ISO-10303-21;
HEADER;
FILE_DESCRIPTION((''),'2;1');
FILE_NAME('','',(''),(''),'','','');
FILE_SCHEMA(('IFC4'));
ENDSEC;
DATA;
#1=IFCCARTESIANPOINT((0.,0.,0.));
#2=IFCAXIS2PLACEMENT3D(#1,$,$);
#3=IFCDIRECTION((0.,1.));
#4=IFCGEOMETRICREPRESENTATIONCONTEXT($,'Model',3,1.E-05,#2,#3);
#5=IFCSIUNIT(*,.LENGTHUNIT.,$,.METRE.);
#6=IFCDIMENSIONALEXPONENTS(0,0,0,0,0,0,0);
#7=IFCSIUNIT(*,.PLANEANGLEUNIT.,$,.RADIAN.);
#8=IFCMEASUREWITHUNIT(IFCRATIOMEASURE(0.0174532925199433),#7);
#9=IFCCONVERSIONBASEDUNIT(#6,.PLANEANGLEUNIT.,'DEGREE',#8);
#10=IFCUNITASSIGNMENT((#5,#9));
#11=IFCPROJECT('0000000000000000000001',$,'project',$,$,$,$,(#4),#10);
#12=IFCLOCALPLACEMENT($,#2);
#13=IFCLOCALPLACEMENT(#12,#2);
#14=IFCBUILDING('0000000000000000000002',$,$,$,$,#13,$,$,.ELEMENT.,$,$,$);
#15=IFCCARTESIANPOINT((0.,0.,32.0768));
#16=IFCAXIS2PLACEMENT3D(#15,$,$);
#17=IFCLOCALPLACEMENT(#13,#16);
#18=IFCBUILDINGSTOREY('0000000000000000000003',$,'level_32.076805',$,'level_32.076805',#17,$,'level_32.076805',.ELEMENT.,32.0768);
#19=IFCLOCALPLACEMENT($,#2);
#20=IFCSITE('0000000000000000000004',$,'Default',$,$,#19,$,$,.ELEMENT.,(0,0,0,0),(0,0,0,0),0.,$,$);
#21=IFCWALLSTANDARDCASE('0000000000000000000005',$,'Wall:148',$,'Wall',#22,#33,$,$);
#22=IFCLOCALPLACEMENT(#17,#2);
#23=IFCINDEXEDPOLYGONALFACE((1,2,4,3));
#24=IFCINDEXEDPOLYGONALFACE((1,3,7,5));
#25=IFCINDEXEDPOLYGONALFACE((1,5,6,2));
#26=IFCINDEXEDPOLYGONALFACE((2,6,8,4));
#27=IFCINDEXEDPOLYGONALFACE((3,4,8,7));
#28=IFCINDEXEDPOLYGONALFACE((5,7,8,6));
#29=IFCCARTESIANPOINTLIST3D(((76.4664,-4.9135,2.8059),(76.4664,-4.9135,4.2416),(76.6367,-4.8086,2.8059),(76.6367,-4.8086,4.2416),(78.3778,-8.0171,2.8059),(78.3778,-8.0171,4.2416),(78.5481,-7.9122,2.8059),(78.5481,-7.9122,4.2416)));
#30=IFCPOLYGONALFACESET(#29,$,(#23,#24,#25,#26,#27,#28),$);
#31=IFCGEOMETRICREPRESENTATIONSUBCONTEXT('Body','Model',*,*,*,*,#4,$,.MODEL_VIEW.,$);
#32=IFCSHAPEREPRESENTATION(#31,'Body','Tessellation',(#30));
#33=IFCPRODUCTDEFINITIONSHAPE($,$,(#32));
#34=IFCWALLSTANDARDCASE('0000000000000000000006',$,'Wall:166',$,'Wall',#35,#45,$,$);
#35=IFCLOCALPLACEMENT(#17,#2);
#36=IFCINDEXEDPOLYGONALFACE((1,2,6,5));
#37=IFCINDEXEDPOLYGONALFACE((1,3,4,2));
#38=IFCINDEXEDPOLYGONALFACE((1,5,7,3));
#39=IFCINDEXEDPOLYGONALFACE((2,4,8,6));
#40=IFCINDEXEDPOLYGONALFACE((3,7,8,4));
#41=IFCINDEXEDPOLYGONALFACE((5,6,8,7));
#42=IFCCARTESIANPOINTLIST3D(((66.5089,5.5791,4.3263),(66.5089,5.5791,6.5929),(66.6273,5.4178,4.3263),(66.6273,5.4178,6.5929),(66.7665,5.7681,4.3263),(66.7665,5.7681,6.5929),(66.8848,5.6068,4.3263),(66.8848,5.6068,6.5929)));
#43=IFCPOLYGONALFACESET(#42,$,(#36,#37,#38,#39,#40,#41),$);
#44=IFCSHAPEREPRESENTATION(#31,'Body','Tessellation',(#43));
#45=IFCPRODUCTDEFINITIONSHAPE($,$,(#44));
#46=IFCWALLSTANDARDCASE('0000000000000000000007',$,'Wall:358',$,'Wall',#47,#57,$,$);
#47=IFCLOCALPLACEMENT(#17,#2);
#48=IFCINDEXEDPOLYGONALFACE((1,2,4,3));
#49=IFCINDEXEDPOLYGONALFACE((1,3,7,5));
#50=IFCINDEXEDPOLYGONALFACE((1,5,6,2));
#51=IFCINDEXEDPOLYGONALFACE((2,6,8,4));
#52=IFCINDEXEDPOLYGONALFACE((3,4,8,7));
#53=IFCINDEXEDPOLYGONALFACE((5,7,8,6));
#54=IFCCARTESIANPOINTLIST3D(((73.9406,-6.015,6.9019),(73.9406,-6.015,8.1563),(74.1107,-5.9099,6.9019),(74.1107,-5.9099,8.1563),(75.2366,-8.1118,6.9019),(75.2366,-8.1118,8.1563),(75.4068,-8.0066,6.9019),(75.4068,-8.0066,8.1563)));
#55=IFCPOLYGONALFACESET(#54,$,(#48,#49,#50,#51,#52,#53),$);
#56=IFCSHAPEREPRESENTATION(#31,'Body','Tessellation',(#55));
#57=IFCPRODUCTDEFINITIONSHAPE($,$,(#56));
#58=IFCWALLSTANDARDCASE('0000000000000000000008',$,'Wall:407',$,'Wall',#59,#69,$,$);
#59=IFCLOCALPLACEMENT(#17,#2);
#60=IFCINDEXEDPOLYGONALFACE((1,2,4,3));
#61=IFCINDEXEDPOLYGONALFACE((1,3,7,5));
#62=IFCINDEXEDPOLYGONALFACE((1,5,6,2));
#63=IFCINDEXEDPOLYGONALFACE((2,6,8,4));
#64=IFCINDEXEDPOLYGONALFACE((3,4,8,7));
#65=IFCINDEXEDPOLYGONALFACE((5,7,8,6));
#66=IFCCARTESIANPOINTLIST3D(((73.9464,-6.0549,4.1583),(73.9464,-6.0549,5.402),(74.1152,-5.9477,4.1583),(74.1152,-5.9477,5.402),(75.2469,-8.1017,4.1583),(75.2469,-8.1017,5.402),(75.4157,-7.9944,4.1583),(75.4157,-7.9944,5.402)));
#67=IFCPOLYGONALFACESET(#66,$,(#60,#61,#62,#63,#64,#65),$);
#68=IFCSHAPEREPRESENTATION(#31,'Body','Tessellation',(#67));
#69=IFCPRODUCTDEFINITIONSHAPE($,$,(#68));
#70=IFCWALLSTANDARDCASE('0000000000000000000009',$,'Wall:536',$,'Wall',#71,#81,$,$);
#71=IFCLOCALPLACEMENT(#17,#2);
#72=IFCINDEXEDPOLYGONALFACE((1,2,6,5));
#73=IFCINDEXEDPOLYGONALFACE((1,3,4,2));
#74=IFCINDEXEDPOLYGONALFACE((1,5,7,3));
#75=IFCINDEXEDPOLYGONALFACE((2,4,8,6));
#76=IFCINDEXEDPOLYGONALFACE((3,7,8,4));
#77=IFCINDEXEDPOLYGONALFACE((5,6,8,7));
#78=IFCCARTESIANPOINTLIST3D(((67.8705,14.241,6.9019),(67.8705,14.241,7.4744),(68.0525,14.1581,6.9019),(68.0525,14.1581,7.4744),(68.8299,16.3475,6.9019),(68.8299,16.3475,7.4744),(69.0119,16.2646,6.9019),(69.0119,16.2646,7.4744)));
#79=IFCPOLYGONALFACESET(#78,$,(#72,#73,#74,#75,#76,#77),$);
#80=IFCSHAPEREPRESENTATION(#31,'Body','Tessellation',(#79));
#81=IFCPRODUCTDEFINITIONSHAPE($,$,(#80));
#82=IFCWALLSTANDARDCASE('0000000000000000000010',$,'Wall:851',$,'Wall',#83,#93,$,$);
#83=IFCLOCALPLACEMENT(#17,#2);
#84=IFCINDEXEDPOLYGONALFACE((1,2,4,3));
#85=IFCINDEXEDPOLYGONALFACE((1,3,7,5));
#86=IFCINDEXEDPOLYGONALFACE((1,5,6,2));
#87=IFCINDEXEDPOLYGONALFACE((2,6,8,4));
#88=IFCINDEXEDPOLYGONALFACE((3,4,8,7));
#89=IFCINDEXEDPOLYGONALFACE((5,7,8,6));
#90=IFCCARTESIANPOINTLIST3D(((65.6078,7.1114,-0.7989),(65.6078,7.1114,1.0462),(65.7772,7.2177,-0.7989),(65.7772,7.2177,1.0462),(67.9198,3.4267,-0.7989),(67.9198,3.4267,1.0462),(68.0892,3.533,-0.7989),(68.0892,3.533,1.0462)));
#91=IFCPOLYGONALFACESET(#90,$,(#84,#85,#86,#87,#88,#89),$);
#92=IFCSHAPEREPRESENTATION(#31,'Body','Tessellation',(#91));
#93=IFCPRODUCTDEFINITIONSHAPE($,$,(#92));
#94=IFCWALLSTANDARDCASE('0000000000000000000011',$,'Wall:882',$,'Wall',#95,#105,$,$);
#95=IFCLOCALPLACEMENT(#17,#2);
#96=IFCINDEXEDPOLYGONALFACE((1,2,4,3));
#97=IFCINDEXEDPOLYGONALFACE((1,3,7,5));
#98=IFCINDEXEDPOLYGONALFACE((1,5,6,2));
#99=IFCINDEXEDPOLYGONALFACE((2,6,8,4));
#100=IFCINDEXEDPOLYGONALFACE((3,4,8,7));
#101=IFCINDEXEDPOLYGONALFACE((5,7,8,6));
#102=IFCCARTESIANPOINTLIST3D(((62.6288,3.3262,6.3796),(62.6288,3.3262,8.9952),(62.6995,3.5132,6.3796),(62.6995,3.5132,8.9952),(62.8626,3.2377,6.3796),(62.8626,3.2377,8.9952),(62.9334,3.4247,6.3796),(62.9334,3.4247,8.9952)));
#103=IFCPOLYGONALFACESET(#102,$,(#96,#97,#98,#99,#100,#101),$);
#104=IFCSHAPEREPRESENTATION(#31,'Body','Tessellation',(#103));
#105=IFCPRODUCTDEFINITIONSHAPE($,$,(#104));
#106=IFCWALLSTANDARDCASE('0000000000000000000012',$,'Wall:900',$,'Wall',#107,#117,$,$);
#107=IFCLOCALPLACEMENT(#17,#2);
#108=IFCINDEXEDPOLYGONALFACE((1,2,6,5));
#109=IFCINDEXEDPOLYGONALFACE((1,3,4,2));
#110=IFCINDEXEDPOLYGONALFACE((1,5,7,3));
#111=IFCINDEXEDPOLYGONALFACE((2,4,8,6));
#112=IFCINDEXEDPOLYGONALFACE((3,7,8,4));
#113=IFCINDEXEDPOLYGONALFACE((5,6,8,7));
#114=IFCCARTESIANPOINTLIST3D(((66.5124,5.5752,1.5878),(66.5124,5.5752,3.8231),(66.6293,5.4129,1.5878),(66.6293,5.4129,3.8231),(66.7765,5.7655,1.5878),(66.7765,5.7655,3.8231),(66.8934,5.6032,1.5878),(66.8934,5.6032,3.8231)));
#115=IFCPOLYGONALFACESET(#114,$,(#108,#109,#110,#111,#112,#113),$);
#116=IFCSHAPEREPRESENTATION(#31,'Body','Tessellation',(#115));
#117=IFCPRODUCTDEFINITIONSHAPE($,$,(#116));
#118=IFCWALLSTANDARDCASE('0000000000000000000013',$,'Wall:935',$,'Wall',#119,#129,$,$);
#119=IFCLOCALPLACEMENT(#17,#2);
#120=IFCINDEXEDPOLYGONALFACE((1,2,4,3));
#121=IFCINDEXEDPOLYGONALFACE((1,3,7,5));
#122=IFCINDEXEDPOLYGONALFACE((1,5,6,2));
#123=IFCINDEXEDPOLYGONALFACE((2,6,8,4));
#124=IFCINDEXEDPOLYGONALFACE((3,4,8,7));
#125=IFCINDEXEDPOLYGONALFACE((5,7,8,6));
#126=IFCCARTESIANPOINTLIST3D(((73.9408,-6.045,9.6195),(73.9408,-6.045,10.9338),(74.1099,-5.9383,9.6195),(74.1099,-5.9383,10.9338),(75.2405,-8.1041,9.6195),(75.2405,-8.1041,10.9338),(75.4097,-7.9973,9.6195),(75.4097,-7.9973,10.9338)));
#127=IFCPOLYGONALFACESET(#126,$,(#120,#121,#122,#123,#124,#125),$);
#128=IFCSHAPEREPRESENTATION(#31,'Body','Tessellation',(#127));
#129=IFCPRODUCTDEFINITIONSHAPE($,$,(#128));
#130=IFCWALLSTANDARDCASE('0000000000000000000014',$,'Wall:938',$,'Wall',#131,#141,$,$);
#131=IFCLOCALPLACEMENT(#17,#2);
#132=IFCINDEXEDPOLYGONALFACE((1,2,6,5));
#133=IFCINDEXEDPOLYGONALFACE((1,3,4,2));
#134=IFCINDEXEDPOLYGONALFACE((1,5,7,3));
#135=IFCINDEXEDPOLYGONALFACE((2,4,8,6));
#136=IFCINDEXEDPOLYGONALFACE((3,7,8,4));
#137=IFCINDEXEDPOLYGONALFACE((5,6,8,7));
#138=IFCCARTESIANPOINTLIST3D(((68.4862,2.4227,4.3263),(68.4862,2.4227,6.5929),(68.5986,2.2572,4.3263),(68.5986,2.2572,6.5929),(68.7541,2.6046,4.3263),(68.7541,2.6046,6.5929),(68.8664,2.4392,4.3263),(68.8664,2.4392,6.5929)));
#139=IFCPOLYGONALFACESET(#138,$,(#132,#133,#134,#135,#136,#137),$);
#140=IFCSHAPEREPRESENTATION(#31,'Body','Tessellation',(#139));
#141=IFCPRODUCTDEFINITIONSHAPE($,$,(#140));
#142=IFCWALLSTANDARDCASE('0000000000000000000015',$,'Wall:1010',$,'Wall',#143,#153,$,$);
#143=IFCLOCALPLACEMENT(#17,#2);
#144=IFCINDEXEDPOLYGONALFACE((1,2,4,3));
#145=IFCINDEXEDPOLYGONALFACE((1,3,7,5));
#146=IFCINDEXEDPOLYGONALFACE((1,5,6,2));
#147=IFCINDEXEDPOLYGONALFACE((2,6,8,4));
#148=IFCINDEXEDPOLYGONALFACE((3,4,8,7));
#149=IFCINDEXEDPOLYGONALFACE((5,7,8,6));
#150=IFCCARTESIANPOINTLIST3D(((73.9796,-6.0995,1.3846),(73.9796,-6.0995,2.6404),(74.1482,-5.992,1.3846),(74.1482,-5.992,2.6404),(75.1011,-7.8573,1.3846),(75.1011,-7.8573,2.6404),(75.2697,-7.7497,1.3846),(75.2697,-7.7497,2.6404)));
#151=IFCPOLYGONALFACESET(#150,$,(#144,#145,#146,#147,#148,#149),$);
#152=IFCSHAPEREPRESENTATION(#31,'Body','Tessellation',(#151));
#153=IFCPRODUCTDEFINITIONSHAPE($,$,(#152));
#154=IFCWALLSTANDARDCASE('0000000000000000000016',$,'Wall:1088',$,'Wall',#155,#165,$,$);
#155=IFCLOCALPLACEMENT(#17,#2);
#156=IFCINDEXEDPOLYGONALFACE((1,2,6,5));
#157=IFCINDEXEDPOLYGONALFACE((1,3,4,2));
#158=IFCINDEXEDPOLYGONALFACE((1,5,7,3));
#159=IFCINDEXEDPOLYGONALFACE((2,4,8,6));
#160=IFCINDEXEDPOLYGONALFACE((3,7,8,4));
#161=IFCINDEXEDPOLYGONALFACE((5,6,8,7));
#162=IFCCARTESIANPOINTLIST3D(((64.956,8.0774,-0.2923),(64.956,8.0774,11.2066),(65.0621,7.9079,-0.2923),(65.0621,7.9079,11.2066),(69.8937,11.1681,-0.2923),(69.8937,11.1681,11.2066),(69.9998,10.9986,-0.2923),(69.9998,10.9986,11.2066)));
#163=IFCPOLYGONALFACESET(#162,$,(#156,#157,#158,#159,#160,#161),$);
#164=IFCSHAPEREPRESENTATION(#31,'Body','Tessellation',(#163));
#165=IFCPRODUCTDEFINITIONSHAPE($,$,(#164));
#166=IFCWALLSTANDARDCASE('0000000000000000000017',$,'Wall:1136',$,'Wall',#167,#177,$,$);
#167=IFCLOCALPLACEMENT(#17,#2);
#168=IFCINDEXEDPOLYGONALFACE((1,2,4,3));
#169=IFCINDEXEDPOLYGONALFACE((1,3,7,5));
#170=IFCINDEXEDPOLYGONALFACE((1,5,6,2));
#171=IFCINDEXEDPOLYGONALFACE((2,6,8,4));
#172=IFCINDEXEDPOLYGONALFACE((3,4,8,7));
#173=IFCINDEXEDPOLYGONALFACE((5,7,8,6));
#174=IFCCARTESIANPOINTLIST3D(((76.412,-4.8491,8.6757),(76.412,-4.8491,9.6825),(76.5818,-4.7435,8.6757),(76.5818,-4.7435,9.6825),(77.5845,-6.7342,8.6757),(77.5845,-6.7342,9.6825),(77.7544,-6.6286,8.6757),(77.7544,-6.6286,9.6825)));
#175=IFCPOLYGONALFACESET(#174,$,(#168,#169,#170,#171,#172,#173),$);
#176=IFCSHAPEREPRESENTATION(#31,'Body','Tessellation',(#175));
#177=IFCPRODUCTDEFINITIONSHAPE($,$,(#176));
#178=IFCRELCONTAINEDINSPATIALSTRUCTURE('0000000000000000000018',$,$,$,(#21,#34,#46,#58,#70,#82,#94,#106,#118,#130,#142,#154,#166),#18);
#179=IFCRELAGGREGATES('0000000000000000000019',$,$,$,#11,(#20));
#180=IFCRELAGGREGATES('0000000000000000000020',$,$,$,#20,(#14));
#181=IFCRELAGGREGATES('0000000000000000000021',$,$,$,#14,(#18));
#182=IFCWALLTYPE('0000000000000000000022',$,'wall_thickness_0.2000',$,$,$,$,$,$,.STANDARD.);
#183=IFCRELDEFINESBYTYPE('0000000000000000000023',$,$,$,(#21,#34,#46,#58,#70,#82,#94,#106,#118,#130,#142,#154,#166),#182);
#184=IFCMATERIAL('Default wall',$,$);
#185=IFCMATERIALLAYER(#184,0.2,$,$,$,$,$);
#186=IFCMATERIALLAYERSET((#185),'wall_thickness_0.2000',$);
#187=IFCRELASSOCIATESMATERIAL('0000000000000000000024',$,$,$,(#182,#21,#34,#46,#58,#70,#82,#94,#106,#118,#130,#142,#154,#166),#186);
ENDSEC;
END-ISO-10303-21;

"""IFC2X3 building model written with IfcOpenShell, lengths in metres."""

from ifc_helpers import new_model, entity, si_unit, converted_unit, direction, frame, origin, place, context, subcontext, project, spatial, polyline, outline, extrude, material, layer, layer_set, layer_usage, type_object, element, save


model = new_model("IFC2X3")

# Units and contexts
model_context = context("Model", 3, precision=1e-05, world=origin(), true_north=direction((0.0, 1.0)))
body_context = subcontext(model_context, "Body", "Model", "MODEL_VIEW")
ifc_project = project(units=[si_unit("LENGTHUNIT", "METRE"), converted_unit("PLANEANGLEUNIT", "DEGREE", entity("IfcRatioMeasure", 0.0174532925199433), si_unit("PLANEANGLEUNIT", "RADIAN"), dimensions=[0, 0, 0, 0, 0, 0, 0])], contexts=[model_context])

# Site, building, storey
site_placement = place(None, origin())
site = spatial("IfcSite", under=ifc_project, at=site_placement, Name="Default", CompositionType="ELEMENT", RefLatitude=(0, 0, 0, 0), RefLongitude=(0, 0, 0, 0), RefElevation=0.0)
placement_1 = place(None, origin())
building_placement = place(placement_1, origin())
building = spatial("IfcBuilding", under=site, at=building_placement, CompositionType="ELEMENT")
storey_placement = place(building_placement, frame((0.0, 0.0, 32.0768)))
storey = spatial("IfcBuildingStorey", under=building, at=storey_placement, Name="level_32.076805", ObjectType="level_32.076805", LongName="level_32.076805", CompositionType="ELEMENT", Elevation=32.0768)

# Walls
ifc_material_1 = material(Name="Default wall")
ifc_layer = layer(ifc_material_1, 0.2)
ifc_layer_set = layer_set([ifc_layer], Name="wall_thickness_0.2000")
ifc_layer_usage = layer_usage(ifc_layer_set, "AXIS2", "POSITIVE", -0.1)
wall_type = type_object("IfcWallType", Name="wall_thickness_0.2000", PredefinedType="STANDARD", material=ifc_layer_set)
placement_2 = place(building_placement, frame((0.0, 0.0, 34.8827)))
wall_1_placement = place(placement_2, frame((76.5516, -4.861, 0.0), z_axis=(0.0, 0.0, 1.0), x_axis=(0.524394, -0.851476, 0.0)))
element("IfcWallStandardCase", 1, at=wall_1_placement, inside=storey, type_object=wall_type, material=ifc_layer_usage, Name="Wall:148", ObjectType="Wall", context=body_context, shape_type="SweptSolid", body=[
    extrude(outline(polyline([(3.645, -0.1), (3.645, 0.1), (0.0, 0.1), (0.0, -0.1), (3.645, -0.1)])), origin(), (0.0, 0.0, 1.0), 1.4358),
])
placement_3 = place(building_placement, frame((0.0, 0.0, 36.4031)))
wall_2_placement = place(placement_3, frame((66.8256, 5.6874, 0.0), z_axis=(0.0, 0.0, 1.0), x_axis=(-0.806218, -0.591618, 0.0)))
element("IfcWallStandardCase", 2, at=wall_2_placement, inside=storey, type_object=wall_type, material=ifc_layer_usage, Name="Wall:166", ObjectType="Wall", context=body_context, shape_type="SweptSolid", body=[
    extrude(outline(polyline([(0.3194, -0.1), (0.3194, 0.1), (0.0, 0.1), (0.0, -0.1), (0.3194, -0.1)])), origin(), (0.0, 0.0, 1.0), 2.2667),
])
placement_4 = place(building_placement, frame((0.0, 0.0, 38.9787)))
wall_3_placement = place(placement_4, frame((74.0257, -5.9624, 0.0), z_axis=(0.0, 0.0, 1.0), x_axis=(0.525775, -0.850624, 0.0)))
element("IfcWallStandardCase", 3, at=wall_3_placement, inside=storey, type_object=wall_type, material=ifc_layer_usage, Name="Wall:358", ObjectType="Wall", context=body_context, shape_type="SweptSolid", body=[
    extrude(outline(polyline([(2.465, -0.1), (2.465, 0.1), (0.0, 0.1), (0.0, -0.1), (2.465, -0.1)])), origin(), (0.0, 0.0, 1.0), 1.2544),
])
placement_5 = place(building_placement, frame((0.0, 0.0, 36.2351)))
wall_4_placement = place(placement_5, frame((74.0308, -6.0013, 0.0), z_axis=(0.0, 0.0, 1.0), x_axis=(0.536297, -0.844029, 0.0)))
element("IfcWallStandardCase", 4, at=wall_4_placement, inside=storey, type_object=wall_type, material=ifc_layer_usage, Name="Wall:407", ObjectType="Wall", context=body_context, shape_type="SweptSolid", body=[
    extrude(outline(polyline([(2.425, -0.1), (2.425, 0.1), (0.0, 0.1), (0.0, -0.1), (2.425, -0.1)])), origin(), (0.0, 0.0, 1.0), 1.2437),
])
placement_6 = place(building_placement, frame((0.0, 0.0, 38.9787)))
wall_5_placement = place(placement_6, frame((67.9615, 14.1995, 0.0), z_axis=(0.0, 0.0, 1.0), x_axis=(0.414506, 0.910047, 0.0)))
element("IfcWallStandardCase", 5, at=wall_5_placement, inside=storey, type_object=wall_type, material=ifc_layer_usage, Name="Wall:536", ObjectType="Wall", context=body_context, shape_type="SweptSolid", body=[
    extrude(outline(polyline([(2.3147, -0.1), (2.3147, 0.1), (0.0, 0.1), (0.0, -0.1), (2.3147, -0.1)])), origin(), (0.0, 0.0, 1.0), 0.5725),
])
placement_7 = place(building_placement, frame((0.0, 0.0, 31.2779)))
wall_6_placement = place(placement_7, frame((65.6925, 7.1646, 0.0), z_axis=(0.0, 0.0, 1.0), x_axis=(0.531501, -0.847058, 0.0)))
element("IfcWallStandardCase", 6, at=wall_6_placement, inside=storey, type_object=wall_type, material=ifc_layer_usage, Name="Wall:851", ObjectType="Wall", context=body_context, shape_type="SweptSolid", body=[
    extrude(outline(polyline([(4.35, -0.1), (4.35, 0.1), (0.0, 0.1), (0.0, -0.1), (4.35, -0.1)])), origin(), (0.0, 0.0, 1.0), 1.845),
])

# Walls
placement_8 = place(building_placement, frame((0.0, 0.0, 38.4564)))
wall_7_placement = place(placement_8, frame((62.898, 3.3312, 0.0), z_axis=(0.0, 0.0, 1.0), x_axis=(-0.935268, 0.353939, 0.0)))
element("IfcWallStandardCase", 7, at=wall_7_placement, inside=storey, type_object=wall_type, material=ifc_layer_usage, Name="Wall:882", ObjectType="Wall", context=body_context, shape_type="SweptSolid", body=[
    extrude(outline(polyline([(0.25, -0.1), (0.25, 0.1), (0.0, 0.1), (0.0, -0.1), (0.25, -0.1)])), origin(), (0.0, 0.0, 1.0), 2.6156),
])
placement_9 = place(building_placement, frame((0.0, 0.0, 33.6646)))
wall_8_placement = place(placement_9, frame((66.835, 5.6843, 0.0), z_axis=(0.0, 0.0, 1.0), x_axis=(-0.811306, -0.584622, 0.0)))
element("IfcWallStandardCase", 8, at=wall_8_placement, inside=storey, type_object=wall_type, material=ifc_layer_usage, Name="Wall:900", ObjectType="Wall", context=body_context, shape_type="SweptSolid", body=[
    extrude(outline(polyline([(0.3255, -0.1), (0.3255, 0.1), (0.0, 0.1), (0.0, -0.1), (0.3255, -0.1)])), origin(), (0.0, 0.0, 1.0), 2.2353),
])
placement_10 = place(building_placement, frame((0.0, 0.0, 41.6963)))
wall_9_placement = place(placement_10, frame((74.0253, -5.9916, 0.0), z_axis=(0.0, 0.0, 1.0), x_axis=(0.533781, -0.845623, 0.0)))
element("IfcWallStandardCase", 9, at=wall_9_placement, inside=storey, type_object=wall_type, material=ifc_layer_usage, Name="Wall:935", ObjectType="Wall", context=body_context, shape_type="SweptSolid", body=[
    extrude(outline(polyline([(2.435, -0.1), (2.435, 0.1), (0.0, 0.1), (0.0, -0.1), (2.435, -0.1)])), origin(), (0.0, 0.0, 1.0), 1.3142),
])
placement_11 = place(building_placement, frame((0.0, 0.0, 36.4031)))
wall_10_placement = place(placement_11, frame((68.8102, 2.5219, 0.0), z_axis=(0.0, 0.0, 1.0), x_axis=(-0.827236, -0.561854, 0.0)))
element("IfcWallStandardCase", 10, at=wall_10_placement, inside=storey, type_object=wall_type, material=ifc_layer_usage, Name="Wall:938", ObjectType="Wall", context=body_context, shape_type="SweptSolid", body=[
    extrude(outline(polyline([(0.3238, -0.1), (0.3238, 0.1), (0.0, 0.1), (0.0, -0.1), (0.3238, -0.1)])), origin(), (0.0, 0.0, 1.0), 2.2667),
])
placement_12 = place(building_placement, frame((0.0, 0.0, 33.4614)))
wall_11_placement = place(placement_12, frame((74.0639, -6.0457, 0.0), z_axis=(0.0, 0.0, 1.0), x_axis=(0.537851, -0.84304, 0.0)))
element("IfcWallStandardCase", 11, at=wall_11_placement, inside=storey, type_object=wall_type, material=ifc_layer_usage, Name="Wall:1010", ObjectType="Wall", context=body_context, shape_type="SweptSolid", body=[
    extrude(outline(polyline([(2.085, -0.1), (2.085, 0.1), (0.0, 0.1), (0.0, -0.1), (2.085, -0.1)])), origin(), (0.0, 0.0, 1.0), 1.2558),
])
placement_13 = place(building_placement, frame((0.0, 0.0, 31.7845)))
wall_12_placement = place(placement_13, frame((69.9468, 11.0834, 0.0), z_axis=(0.0, 0.0, 1.0), x_axis=(-0.847635, -0.530579, 0.0)))
element("IfcWallStandardCase", 12, at=wall_12_placement, inside=storey, type_object=wall_type, material=ifc_layer_usage, Name="Wall:1088", ObjectType="Wall", context=body_context, shape_type="SweptSolid", body=[
    extrude(outline(polyline([(5.8252, -0.1), (5.8252, 0.1), (0.0, 0.1), (0.0, -0.1), (5.8252, -0.1)])), origin(), (0.0, 0.0, 1.0), 11.4989),
])
placement_14 = place(building_placement, frame((0.0, 0.0, 40.7525)))
wall_13_placement = place(placement_14, frame((76.4969, -4.7963, 0.0), z_axis=(0.0, 0.0, 1.0), x_axis=(0.528174, -0.849136, 0.0)))
element("IfcWallStandardCase", 13, at=wall_13_placement, inside=storey, type_object=wall_type, material=ifc_layer_usage, Name="Wall:1136", ObjectType="Wall", context=body_context, shape_type="SweptSolid", body=[
    extrude(outline(polyline([(2.22, -0.1), (2.22, 0.1), (0.0, 0.1), (0.0, -0.1), (2.22, -0.1)])), origin(), (0.0, 0.0, 1.0), 1.0068),
])

save(model, "model.ifc")
